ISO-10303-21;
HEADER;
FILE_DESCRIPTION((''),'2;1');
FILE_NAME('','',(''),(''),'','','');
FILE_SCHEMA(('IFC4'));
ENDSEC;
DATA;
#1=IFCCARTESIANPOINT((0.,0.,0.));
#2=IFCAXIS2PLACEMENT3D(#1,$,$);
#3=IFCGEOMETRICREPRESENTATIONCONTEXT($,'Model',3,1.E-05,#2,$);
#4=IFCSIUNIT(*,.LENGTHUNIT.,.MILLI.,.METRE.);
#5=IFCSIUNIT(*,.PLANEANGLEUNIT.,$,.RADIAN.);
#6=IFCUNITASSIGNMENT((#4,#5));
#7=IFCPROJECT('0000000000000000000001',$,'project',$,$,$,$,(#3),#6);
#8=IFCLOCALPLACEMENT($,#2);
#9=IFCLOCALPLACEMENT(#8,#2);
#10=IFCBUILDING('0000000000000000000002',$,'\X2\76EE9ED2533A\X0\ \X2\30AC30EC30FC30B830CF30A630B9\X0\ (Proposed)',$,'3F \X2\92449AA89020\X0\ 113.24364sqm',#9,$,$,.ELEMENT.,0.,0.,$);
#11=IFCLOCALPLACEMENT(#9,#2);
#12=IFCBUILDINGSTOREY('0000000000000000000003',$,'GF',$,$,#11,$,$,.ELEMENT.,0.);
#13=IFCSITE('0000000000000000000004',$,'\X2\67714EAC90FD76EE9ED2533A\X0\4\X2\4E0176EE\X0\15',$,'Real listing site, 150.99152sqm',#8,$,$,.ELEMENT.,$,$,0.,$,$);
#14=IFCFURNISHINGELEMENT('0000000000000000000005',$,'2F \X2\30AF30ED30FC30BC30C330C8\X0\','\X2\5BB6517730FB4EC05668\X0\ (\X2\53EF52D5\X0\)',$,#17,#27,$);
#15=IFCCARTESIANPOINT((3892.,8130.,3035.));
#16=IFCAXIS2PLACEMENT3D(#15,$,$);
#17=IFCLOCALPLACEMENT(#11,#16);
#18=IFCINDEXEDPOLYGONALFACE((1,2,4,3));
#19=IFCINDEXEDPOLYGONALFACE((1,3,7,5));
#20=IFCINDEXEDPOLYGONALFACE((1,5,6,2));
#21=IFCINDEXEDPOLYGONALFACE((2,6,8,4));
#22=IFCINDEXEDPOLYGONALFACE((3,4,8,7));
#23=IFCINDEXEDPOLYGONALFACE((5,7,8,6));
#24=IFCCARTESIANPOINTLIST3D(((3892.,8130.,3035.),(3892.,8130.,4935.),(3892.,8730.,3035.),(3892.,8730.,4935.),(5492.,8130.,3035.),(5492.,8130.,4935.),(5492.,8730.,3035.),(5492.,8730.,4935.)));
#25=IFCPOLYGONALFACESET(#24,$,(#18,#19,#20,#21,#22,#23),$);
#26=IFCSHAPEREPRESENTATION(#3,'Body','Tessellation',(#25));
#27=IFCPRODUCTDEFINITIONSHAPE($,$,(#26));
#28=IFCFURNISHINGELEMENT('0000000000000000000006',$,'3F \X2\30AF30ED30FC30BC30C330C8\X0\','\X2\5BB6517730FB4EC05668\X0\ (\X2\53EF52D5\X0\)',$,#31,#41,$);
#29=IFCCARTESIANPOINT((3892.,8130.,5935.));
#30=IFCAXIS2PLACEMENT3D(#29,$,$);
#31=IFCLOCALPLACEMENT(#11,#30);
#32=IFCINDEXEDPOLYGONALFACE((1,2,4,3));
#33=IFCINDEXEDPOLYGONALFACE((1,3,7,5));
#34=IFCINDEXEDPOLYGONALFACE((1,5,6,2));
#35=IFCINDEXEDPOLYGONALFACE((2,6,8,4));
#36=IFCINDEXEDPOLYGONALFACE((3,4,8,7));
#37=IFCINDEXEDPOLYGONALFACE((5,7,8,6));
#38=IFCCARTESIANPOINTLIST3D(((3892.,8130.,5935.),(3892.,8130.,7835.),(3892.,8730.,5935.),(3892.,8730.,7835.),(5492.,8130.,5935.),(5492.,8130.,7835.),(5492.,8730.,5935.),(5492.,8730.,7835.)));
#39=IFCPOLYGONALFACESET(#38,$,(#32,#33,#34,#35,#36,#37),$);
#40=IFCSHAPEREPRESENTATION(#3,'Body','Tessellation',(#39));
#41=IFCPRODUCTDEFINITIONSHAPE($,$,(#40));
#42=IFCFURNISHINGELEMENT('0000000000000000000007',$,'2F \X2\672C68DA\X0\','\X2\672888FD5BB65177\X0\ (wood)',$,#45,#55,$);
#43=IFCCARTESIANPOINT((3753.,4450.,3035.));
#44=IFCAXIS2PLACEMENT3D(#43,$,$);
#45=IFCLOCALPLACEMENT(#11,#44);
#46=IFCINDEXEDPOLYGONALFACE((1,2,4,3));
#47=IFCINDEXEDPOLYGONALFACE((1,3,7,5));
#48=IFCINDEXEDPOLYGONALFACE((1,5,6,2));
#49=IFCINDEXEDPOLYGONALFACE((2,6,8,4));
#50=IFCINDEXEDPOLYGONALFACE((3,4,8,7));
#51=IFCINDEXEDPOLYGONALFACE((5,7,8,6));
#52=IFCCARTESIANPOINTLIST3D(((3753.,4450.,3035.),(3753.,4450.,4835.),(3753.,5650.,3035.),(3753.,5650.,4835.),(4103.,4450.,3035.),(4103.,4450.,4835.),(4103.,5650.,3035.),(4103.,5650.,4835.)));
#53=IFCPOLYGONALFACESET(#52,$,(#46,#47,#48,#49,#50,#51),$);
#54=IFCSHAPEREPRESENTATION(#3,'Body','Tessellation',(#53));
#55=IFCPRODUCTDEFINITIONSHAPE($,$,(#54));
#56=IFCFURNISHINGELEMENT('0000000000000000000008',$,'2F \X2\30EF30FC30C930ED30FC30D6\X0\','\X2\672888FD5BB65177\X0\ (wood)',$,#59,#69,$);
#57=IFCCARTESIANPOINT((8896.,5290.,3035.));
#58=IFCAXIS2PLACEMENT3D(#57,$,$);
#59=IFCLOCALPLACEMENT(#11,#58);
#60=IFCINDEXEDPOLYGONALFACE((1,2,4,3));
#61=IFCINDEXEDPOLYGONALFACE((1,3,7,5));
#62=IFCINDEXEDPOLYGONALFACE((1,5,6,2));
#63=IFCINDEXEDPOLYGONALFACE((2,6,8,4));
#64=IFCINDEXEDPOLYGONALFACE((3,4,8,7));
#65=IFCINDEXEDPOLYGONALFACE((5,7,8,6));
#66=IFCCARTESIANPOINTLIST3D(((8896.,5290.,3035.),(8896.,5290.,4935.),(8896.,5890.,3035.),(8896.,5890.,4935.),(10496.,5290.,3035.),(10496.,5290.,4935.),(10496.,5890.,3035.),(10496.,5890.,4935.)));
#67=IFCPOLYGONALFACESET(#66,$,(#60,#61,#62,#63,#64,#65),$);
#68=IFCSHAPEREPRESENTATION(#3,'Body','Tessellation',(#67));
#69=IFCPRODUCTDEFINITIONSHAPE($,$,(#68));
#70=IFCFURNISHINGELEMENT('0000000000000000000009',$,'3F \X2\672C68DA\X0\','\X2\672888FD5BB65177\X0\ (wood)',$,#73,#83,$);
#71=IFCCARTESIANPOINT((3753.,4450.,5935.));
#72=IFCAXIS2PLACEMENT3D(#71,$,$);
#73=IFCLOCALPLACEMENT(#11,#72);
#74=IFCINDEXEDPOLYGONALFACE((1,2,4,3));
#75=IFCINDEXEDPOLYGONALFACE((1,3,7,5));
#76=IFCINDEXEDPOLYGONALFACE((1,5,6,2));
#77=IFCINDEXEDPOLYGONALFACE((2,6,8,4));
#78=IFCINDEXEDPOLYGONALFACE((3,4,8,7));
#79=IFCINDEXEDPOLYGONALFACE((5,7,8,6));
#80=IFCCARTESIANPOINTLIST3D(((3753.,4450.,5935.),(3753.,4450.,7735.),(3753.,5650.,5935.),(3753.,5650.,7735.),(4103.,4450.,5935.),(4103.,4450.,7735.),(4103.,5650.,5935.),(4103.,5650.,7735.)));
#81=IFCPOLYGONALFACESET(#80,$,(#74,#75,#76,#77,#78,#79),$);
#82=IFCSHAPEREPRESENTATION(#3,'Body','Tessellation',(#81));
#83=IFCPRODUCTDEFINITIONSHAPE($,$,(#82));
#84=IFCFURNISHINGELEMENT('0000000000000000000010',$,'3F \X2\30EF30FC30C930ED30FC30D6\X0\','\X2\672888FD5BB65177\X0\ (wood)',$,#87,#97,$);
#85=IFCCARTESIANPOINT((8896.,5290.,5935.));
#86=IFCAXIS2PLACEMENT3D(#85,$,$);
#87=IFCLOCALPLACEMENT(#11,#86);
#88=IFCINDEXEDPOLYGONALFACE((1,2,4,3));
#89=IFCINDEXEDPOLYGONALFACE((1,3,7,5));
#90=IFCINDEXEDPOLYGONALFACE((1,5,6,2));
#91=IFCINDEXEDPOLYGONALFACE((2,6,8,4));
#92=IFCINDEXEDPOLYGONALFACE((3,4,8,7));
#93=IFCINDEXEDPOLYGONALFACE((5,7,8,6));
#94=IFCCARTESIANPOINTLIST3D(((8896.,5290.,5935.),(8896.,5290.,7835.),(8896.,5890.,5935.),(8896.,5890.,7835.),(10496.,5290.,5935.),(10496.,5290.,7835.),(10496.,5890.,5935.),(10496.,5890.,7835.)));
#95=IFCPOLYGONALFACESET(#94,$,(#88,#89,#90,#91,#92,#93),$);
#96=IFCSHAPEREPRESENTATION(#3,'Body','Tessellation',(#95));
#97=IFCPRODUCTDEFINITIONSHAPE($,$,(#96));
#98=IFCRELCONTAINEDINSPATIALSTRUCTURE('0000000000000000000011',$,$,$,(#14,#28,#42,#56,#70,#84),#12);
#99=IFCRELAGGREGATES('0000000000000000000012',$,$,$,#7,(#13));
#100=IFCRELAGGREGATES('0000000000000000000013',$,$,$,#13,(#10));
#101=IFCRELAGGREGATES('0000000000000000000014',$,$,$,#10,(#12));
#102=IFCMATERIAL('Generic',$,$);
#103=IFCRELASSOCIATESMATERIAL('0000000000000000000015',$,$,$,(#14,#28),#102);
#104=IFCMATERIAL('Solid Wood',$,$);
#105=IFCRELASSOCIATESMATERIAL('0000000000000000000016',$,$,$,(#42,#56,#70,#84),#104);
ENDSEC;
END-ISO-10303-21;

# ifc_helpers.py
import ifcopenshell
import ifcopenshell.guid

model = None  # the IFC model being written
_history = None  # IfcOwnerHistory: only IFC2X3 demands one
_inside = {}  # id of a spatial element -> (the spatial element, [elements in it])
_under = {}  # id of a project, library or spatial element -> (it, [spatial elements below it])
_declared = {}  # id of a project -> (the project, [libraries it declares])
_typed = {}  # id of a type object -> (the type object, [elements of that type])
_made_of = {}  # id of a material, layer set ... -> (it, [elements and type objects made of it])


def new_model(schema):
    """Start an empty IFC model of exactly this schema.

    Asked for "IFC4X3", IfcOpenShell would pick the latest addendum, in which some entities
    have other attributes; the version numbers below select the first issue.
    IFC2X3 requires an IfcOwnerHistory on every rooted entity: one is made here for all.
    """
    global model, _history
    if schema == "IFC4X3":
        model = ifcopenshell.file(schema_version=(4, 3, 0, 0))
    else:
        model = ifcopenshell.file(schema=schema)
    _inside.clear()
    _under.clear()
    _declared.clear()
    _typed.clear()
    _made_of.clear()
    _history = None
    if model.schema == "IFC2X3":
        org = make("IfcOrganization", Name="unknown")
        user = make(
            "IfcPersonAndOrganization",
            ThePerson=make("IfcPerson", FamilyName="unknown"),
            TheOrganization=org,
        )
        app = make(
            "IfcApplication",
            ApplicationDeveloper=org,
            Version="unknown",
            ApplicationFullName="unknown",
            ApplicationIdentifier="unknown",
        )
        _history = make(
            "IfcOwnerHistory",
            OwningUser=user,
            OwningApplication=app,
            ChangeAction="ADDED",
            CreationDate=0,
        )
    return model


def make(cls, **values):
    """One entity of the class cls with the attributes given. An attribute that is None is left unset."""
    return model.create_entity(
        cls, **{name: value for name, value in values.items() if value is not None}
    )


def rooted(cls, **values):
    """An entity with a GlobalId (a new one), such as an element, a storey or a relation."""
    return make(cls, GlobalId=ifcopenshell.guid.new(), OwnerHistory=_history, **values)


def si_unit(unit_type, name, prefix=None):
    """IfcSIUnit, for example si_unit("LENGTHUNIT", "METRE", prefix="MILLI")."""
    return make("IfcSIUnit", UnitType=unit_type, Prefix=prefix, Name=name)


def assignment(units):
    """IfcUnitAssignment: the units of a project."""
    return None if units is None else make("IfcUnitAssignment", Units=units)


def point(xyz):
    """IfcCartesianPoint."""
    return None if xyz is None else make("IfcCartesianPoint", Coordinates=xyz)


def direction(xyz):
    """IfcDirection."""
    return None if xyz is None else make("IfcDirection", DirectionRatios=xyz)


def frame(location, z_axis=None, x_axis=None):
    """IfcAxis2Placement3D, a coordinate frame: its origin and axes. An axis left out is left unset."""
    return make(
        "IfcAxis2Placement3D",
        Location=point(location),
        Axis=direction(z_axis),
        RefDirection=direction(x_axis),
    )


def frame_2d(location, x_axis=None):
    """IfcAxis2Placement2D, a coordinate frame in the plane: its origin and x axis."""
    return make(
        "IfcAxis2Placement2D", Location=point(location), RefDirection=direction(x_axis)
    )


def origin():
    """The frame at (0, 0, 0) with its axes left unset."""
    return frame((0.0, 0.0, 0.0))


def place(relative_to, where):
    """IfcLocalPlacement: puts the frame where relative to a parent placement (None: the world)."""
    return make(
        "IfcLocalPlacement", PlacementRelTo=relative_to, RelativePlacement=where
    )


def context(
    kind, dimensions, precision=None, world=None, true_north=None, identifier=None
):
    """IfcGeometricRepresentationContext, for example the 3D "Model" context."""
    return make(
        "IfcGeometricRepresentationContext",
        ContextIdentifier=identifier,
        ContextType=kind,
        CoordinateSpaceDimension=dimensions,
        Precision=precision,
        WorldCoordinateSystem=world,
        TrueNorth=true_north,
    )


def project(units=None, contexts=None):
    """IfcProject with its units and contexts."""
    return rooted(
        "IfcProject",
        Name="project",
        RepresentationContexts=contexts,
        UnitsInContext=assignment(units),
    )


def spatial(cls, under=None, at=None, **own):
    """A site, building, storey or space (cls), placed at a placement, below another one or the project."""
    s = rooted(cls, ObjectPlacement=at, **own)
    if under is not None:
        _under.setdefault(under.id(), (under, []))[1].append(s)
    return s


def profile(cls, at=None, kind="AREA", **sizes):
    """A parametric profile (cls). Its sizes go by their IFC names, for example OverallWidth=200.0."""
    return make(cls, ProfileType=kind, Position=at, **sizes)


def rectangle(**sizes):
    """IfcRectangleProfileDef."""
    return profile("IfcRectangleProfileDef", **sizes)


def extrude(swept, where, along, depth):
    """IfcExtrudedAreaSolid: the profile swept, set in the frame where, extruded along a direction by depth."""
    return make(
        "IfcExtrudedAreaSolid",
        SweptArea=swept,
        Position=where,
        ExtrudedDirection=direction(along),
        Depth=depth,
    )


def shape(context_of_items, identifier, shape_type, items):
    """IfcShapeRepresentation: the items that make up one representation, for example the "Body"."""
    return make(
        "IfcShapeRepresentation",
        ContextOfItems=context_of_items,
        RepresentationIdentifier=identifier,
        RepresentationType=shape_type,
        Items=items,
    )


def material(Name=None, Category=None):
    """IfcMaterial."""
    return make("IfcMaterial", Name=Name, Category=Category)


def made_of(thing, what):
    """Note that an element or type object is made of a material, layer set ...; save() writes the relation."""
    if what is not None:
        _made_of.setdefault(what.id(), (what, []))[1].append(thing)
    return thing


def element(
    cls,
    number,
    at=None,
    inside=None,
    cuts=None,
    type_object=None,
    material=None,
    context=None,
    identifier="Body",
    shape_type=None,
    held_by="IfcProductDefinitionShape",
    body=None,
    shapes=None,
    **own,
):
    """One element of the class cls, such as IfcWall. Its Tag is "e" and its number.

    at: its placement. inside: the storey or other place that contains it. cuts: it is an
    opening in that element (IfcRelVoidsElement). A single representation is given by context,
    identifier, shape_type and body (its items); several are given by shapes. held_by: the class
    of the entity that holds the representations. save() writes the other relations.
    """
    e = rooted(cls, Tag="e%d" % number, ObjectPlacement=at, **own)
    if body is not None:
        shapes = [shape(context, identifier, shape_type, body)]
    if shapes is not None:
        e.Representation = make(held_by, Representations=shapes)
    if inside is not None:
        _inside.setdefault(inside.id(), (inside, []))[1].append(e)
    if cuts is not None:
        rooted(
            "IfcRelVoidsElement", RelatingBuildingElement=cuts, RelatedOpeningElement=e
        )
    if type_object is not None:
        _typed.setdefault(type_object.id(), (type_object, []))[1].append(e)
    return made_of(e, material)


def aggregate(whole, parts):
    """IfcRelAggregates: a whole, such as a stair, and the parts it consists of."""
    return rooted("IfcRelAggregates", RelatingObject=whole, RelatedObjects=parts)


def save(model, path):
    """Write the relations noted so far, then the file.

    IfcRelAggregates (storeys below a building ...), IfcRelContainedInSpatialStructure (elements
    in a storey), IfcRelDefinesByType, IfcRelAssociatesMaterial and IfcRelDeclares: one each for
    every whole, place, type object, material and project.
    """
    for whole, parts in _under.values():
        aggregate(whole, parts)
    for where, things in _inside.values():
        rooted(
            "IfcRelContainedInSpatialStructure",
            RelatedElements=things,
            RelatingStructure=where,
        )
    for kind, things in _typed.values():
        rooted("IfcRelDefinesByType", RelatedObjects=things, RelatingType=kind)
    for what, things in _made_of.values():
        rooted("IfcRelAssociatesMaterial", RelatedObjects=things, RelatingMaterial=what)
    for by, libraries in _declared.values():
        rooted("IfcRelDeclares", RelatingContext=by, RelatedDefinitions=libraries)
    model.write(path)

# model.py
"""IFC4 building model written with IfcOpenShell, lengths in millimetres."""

from ifc_helpers import new_model, si_unit, frame, frame_2d, origin, place, context, project, spatial, rectangle, extrude, material, element, save


model = new_model("IFC4")

# Units and contexts
model_context = context("Model", 3, precision=1e-05, world=origin())
ifc_project = project(units=[si_unit("LENGTHUNIT", "METRE", prefix="MILLI"), si_unit("PLANEANGLEUNIT", "RADIAN")], contexts=[model_context])

# Site, building, storey
site_placement = place(None, origin())
site = spatial("IfcSite", under=ifc_project, at=site_placement, Name="東京都目黒区4丁目15", ObjectType="Real listing site, 150.99152sqm", CompositionType="ELEMENT", RefElevation=0.0)
building_placement = place(site_placement, origin())
building = spatial("IfcBuilding", under=site, at=building_placement, Name="目黒区 ガレージハウス (Proposed)", ObjectType="3F 鉄骨造 113.24364sqm", CompositionType="ELEMENT", ElevationOfRefHeight=0.0, ElevationOfTerrain=0.0)
storey_placement = place(building_placement, origin())
storey = spatial("IfcBuildingStorey", under=building, at=storey_placement, Name="GF", CompositionType="ELEMENT", Elevation=0.0)

# Shared definitions
ifc_material_1 = material(Name="Solid Wood")

# Shared definitions
ifc_material_2 = material(Name="Generic")

# Furnishing elements
furnishing_1_placement = place(storey_placement, frame((3892.0, 8130.0, 3035.0)))
element("IfcFurnishingElement", 1, at=furnishing_1_placement, inside=storey, material=ifc_material_2, Name="2F クローゼット", Description="家具・什器 (可動)", context=model_context, shape_type="SweptSolid", body=[
    extrude(rectangle(XDim=1600.0, YDim=600.0, at=frame_2d((800.0, 300.0))), frame((3892.0, 8130.0, 3035.0)), (0.0, 0.0, 1.0), 1900.0),
])
furnishing_2_placement = place(storey_placement, frame((3892.0, 8130.0, 5935.0)))
element("IfcFurnishingElement", 2, at=furnishing_2_placement, inside=storey, material=ifc_material_2, Name="3F クローゼット", Description="家具・什器 (可動)", context=model_context, shape_type="SweptSolid", body=[
    extrude(rectangle(XDim=1600.0, YDim=600.0, at=frame_2d((800.0, 300.0))), frame((3892.0, 8130.0, 5935.0)), (0.0, 0.0, 1.0), 1900.0),
])
furnishing_3_placement = place(storey_placement, frame((3753.0, 4450.0, 3035.0)))
element("IfcFurnishingElement", 3, at=furnishing_3_placement, inside=storey, material=ifc_material_1, Name="2F 本棚", Description="木製家具 (wood)", context=model_context, shape_type="SweptSolid", body=[
    extrude(rectangle(XDim=350.0, YDim=1200.0, at=frame_2d((175.0, 600.0))), frame((3753.0, 4450.0, 3035.0)), (0.0, 0.0, 1.0), 1800.0),
])
furnishing_4_placement = place(storey_placement, frame((8896.0, 5290.0, 3035.0)))
element("IfcFurnishingElement", 4, at=furnishing_4_placement, inside=storey, material=ifc_material_1, Name="2F ワードローブ", Description="木製家具 (wood)", context=model_context, shape_type="SweptSolid", body=[
    extrude(rectangle(XDim=1600.0, YDim=600.0, at=frame_2d((800.0, 300.0))), frame((8896.0, 5290.0, 3035.0)), (0.0, 0.0, 1.0), 1900.0),
])
furnishing_5_placement = place(storey_placement, frame((3753.0, 4450.0, 5935.0)))
element("IfcFurnishingElement", 5, at=furnishing_5_placement, inside=storey, material=ifc_material_1, Name="3F 本棚", Description="木製家具 (wood)", context=model_context, shape_type="SweptSolid", body=[
    extrude(rectangle(XDim=350.0, YDim=1200.0, at=frame_2d((175.0, 600.0))), frame((3753.0, 4450.0, 5935.0)), (0.0, 0.0, 1.0), 1800.0),
])
furnishing_6_placement = place(storey_placement, frame((8896.0, 5290.0, 5935.0)))
element("IfcFurnishingElement", 6, at=furnishing_6_placement, inside=storey, material=ifc_material_1, Name="3F ワードローブ", Description="木製家具 (wood)", context=model_context, shape_type="SweptSolid", body=[
    extrude(rectangle(XDim=1600.0, YDim=600.0, at=frame_2d((800.0, 300.0))), frame((8896.0, 5290.0, 5935.0)), (0.0, 0.0, 1.0), 1900.0),
])

save(model, "model.ifc")
